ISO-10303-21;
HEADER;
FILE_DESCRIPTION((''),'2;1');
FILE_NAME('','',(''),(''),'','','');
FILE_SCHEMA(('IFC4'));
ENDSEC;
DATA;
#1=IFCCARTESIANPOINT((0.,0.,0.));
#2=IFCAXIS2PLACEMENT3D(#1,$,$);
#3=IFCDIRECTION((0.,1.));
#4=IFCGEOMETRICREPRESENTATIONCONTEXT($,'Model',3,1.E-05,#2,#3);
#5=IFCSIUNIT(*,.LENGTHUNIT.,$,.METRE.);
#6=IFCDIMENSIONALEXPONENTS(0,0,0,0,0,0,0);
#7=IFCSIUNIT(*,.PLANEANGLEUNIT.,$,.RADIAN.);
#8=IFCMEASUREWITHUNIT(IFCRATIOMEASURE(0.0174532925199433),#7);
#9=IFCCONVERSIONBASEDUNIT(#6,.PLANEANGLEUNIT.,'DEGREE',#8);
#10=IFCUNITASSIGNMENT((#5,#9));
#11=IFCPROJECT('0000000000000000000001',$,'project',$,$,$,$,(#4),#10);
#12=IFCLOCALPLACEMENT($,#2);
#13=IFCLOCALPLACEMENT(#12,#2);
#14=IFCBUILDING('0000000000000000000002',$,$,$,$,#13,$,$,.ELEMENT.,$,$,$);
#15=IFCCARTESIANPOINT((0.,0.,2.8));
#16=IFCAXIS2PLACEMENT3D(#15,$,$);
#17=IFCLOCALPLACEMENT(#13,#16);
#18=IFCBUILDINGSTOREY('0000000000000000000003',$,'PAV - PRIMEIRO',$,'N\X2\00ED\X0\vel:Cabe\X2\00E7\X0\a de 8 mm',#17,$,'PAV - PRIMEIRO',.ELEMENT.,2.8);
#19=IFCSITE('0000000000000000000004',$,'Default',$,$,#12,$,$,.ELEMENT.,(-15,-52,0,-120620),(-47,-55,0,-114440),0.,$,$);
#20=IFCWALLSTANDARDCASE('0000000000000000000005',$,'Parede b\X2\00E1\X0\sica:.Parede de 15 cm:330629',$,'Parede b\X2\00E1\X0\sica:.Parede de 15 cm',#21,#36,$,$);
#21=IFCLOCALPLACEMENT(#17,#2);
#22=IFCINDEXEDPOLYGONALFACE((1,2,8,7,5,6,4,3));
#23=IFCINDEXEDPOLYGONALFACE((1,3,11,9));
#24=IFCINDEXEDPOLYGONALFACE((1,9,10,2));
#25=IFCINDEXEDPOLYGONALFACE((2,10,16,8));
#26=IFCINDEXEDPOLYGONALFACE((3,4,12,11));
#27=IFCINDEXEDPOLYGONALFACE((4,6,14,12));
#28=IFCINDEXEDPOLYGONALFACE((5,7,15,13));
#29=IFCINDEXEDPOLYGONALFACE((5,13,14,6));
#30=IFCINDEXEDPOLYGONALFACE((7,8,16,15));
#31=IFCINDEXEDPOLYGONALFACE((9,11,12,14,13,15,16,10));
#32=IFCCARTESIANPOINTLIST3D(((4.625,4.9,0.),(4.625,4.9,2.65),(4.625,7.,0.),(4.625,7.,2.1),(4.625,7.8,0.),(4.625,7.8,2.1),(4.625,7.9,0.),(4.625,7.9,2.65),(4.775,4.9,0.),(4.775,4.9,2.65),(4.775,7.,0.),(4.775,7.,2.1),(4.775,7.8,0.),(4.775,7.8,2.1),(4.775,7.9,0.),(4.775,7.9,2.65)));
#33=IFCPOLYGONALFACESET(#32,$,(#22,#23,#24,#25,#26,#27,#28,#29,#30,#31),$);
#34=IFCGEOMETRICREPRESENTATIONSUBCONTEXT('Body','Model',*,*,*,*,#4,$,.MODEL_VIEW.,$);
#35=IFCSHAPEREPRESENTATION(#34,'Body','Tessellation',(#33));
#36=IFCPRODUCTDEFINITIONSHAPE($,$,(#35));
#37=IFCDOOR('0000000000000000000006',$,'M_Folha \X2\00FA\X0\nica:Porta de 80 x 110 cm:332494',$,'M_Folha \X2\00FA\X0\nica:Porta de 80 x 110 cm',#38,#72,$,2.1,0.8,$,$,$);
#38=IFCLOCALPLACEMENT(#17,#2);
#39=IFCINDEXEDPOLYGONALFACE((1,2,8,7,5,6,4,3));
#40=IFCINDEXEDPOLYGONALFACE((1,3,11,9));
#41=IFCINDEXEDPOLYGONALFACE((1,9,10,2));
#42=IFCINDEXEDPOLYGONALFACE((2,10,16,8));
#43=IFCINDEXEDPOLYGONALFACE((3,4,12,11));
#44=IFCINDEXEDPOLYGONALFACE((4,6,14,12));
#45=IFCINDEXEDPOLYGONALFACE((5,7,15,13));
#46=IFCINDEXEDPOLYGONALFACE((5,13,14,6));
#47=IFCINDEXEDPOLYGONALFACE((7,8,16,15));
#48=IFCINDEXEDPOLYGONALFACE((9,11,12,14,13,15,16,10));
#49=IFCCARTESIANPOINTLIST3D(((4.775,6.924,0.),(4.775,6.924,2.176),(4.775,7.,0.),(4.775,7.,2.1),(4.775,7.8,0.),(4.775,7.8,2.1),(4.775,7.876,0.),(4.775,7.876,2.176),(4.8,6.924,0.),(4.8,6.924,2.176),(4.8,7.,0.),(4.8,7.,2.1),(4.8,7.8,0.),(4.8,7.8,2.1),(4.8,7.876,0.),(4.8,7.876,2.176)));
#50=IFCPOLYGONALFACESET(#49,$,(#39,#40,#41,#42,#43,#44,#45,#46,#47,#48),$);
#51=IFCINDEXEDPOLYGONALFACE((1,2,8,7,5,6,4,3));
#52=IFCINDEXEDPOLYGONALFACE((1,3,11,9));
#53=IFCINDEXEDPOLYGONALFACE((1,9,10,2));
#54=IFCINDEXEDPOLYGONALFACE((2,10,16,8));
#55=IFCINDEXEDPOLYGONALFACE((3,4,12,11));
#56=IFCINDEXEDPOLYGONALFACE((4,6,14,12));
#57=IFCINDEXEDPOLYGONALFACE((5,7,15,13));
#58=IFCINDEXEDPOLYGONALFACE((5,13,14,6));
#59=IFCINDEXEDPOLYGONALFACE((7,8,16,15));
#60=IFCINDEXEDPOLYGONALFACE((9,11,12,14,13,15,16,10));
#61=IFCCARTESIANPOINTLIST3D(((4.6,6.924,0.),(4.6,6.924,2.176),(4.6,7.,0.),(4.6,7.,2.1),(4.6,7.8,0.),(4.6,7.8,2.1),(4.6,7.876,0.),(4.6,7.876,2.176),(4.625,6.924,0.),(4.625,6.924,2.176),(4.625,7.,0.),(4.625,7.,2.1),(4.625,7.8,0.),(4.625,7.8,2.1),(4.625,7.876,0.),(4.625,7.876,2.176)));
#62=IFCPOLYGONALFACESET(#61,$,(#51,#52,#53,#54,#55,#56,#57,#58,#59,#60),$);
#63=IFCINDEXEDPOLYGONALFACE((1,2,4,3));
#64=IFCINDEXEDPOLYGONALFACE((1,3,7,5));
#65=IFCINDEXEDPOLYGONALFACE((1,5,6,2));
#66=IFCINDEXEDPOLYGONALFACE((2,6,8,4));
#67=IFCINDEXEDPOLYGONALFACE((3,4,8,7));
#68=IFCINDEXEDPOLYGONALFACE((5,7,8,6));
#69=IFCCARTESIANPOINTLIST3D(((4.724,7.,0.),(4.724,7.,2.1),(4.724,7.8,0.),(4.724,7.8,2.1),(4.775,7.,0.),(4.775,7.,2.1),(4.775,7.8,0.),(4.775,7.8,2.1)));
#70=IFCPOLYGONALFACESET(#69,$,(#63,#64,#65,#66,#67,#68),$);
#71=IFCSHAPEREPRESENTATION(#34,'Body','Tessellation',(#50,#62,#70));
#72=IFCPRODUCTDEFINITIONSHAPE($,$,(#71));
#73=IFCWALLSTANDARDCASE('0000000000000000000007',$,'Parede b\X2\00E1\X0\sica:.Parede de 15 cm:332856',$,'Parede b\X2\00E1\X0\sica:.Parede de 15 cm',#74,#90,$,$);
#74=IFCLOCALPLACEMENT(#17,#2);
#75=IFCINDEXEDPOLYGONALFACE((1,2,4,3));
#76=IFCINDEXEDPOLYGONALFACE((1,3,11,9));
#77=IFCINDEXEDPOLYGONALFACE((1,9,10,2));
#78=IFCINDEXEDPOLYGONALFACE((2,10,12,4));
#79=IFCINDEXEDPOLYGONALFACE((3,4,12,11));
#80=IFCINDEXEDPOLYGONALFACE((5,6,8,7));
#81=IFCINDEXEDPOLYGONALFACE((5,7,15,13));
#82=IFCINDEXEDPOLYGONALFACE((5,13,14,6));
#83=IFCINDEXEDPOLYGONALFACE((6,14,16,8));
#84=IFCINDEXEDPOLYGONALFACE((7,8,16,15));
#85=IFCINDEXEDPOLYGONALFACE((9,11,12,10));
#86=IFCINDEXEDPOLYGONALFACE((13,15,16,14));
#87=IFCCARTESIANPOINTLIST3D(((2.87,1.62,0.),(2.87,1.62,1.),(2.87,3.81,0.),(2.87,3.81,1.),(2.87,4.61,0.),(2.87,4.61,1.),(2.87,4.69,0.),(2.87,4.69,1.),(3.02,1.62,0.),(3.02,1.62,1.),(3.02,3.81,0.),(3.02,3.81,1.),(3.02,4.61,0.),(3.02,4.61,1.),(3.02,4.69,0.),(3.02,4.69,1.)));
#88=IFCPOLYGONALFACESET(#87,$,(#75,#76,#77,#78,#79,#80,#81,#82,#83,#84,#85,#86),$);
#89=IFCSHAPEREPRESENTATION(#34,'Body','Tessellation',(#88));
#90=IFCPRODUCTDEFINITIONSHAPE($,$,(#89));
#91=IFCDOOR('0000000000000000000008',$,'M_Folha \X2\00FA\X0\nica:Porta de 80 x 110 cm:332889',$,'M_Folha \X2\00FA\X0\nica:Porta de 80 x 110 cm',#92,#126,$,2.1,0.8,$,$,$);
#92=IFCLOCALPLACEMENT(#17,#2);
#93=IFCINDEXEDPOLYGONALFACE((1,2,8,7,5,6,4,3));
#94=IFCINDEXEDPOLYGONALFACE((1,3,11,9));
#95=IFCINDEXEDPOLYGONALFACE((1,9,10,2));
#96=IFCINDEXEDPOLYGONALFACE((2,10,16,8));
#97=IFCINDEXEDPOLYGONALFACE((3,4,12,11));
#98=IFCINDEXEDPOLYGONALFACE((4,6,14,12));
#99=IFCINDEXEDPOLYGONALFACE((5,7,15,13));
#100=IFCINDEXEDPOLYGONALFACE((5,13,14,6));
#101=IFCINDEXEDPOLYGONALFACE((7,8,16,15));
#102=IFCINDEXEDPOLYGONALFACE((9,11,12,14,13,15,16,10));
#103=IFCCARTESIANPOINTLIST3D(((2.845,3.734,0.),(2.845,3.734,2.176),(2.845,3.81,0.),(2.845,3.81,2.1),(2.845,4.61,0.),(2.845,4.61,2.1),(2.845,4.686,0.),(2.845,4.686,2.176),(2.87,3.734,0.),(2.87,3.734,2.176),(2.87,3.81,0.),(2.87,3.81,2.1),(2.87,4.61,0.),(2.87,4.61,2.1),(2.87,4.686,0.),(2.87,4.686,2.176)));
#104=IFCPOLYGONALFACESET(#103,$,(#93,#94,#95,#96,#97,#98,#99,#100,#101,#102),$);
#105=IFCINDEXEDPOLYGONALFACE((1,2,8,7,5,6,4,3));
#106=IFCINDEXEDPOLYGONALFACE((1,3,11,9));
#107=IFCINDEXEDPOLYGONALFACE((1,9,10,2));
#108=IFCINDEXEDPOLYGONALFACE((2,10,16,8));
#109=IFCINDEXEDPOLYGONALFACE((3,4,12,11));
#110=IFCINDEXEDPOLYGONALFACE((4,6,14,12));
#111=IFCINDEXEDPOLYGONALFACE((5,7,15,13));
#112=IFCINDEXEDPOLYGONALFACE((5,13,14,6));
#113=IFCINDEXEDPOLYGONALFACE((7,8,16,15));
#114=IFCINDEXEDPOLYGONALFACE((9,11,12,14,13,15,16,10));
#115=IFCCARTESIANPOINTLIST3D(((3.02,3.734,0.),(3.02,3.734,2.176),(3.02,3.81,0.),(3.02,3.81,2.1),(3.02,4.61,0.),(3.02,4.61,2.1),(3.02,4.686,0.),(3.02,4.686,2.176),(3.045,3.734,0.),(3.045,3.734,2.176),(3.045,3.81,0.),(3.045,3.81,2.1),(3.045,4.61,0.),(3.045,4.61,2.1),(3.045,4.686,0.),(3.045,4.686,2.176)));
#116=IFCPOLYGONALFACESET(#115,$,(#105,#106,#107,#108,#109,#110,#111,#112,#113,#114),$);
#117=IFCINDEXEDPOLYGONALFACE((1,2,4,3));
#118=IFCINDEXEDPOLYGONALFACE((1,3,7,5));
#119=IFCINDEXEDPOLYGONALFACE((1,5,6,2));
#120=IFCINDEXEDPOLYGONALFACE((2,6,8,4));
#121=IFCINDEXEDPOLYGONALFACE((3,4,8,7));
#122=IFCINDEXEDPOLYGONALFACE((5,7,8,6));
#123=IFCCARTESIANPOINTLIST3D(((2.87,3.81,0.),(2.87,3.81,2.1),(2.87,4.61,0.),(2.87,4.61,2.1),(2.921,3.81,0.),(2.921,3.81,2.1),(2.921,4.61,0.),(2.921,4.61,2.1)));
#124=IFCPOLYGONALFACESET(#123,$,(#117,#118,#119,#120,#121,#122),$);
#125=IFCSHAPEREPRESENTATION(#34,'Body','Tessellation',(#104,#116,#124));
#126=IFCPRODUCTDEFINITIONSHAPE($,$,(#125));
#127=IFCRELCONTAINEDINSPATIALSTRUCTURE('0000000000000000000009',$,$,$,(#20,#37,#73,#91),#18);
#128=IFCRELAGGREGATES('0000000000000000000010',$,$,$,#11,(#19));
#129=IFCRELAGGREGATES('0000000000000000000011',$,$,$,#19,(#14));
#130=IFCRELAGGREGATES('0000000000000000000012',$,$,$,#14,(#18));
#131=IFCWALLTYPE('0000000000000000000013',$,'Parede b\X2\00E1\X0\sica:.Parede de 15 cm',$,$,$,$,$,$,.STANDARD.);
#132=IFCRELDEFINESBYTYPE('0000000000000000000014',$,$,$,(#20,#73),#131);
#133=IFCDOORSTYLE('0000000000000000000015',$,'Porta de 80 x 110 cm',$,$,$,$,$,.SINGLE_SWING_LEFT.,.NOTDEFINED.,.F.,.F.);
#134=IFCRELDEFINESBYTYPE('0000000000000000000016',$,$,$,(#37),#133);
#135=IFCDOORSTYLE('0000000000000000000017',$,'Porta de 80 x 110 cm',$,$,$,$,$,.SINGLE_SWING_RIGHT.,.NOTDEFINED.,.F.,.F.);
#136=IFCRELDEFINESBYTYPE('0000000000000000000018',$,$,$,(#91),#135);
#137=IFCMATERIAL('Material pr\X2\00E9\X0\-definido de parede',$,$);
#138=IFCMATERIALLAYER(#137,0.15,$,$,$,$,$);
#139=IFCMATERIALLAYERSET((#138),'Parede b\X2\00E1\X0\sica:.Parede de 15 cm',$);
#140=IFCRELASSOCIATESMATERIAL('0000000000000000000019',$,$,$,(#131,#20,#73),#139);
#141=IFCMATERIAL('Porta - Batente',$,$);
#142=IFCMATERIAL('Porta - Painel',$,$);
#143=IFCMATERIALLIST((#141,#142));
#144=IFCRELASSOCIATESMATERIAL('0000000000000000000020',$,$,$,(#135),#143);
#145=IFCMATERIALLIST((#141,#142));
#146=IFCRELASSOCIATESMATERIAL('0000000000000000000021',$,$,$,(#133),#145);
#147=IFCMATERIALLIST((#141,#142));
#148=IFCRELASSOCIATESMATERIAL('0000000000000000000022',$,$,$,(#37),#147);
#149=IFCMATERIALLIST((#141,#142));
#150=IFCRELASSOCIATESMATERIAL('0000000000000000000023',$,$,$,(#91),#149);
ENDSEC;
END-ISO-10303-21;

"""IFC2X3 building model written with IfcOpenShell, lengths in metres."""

from ifc_helpers import new_model, entity, si_unit, converted_unit, direction, frame, frame_2d, origin, place, context, subcontext, project, spatial, polyline, rectangle, outline, extrude, clip, bounded_halfspace, source, transform, mapped, material, material_list, layer, layer_set, layer_usage, type_object, type_shapes, element, fill, save


model = new_model("IFC2X3")

# Units and contexts
model_context = context("Model", 3, precision=1e-05, world=origin(), true_north=direction((0.0, 1.0)))
body_context = subcontext(model_context, "Body", "Model", "MODEL_VIEW")
ifc_project = project(units=[si_unit("LENGTHUNIT", "METRE"), converted_unit("PLANEANGLEUNIT", "DEGREE", entity("IfcRatioMeasure", 0.0174532925199433), si_unit("PLANEANGLEUNIT", "RADIAN"), dimensions=[0, 0, 0, 0, 0, 0, 0])], contexts=[model_context])

# Site, building, storey
site_placement = place(None, origin())
site = spatial("IfcSite", under=ifc_project, at=site_placement, Name="Default", CompositionType="ELEMENT", RefLatitude=(-15, -52, 0, -120620), RefLongitude=(-47, -55, 0, -114440), RefElevation=0.0)
building_placement = place(site_placement, origin())
building = spatial("IfcBuilding", under=site, at=building_placement, CompositionType="ELEMENT")
storey_placement = place(building_placement, frame((0.0, 0.0, 2.8)))
storey = spatial("IfcBuildingStorey", under=building, at=storey_placement, Name="PAV - PRIMEIRO", ObjectType="Nível:Cabeça de 8 mm", LongName="PAV - PRIMEIRO", CompositionType="ELEMENT", Elevation=2.8)

# Shared definitions
ifc_material_1 = material(Name="Material pré-definido de parede")

# Shared definitions
ifc_material_2 = material(Name="Porta - Batente")
ifc_material_3 = material(Name="Porta - Painel")

# Walls, openings, doors
ifc_layer_1 = layer(ifc_material_1, 0.15)
ifc_layer_set_1 = layer_set([ifc_layer_1], Name="Parede básica:.Parede de 15 cm")
wall_type_1 = type_object("IfcWallType", Name="Parede básica:.Parede de 15 cm", PredefinedType="STANDARD", material=ifc_layer_set_1)
ifc_material_list_1 = material_list([ifc_material_2, ifc_material_3])
door_style_1 = type_object("IfcDoorStyle", Name="Porta de 80 x 110 cm", ConstructionType="NOTDEFINED", OperationType="SINGLE_SWING_RIGHT", ParameterTakesPrecedence=False, Sizeable=False, material=ifc_material_list_1)
shared_shape_1 = source(origin(), body_context, "Body", "SweptSolid", [
    extrude(outline(polyline([(-0.476, -1.107), (0.476, -1.107), (0.476, 1.069), (0.4, 1.069), (0.4, -1.031), (-0.4, -1.031), (-0.4, 1.069), (-0.476, 1.069), (-0.476, -1.107)])), frame((0.4, 0.15, 1.069), z_axis=(0.0, 1.0, 0.0), x_axis=(1.0, 0.0, 0.0)), (0.0, 0.0, 1.0), 0.025),
    extrude(outline(polyline([(-1.107, -0.476), (1.069, -0.476), (1.069, -0.4), (-1.031, -0.4), (-1.031, 0.4), (1.069, 0.4), (1.069, 0.476), (-1.107, 0.476), (-1.107, -0.476)])), frame((0.4, -0.025, 1.069), z_axis=(0.0, 1.0, 0.0), x_axis=(0.0, 0.0, -1.0)), (0.0, 0.0, 1.0), 0.025),
    extrude(rectangle(XDim=0.051, YDim=0.8, at=frame_2d((0.0, 0.0), x_axis=(1.0, 0.0))), frame((0.4, 0.1245, 0.0), z_axis=(0.0, 0.0, 1.0), x_axis=(0.0, 1.0, 0.0)), (0.0, 0.0, 1.0), 2.1),
])
type_shapes(door_style_1, [shared_shape_1])
ifc_layer_usage_1 = layer_usage(ifc_layer_set_1, "AXIS2", "NEGATIVE", 0.075)
wall_1_placement = place(storey_placement, frame((4.7, 4.9, 0.0), z_axis=(0.0, 0.0, 1.0), x_axis=(0.0, 1.0, 0.0)))
wall_1 = element("IfcWallStandardCase", 1, at=wall_1_placement, inside=storey, type_object=wall_type_1, material=ifc_layer_usage_1, Name="Parede básica:.Parede de 15 cm:330629", ObjectType="Parede básica:.Parede de 15 cm", context=body_context, shape_type="Clipping", body=[
    clip(extrude(rectangle(XDim=3.0, YDim=0.15, at=frame_2d((1.5, 0.0), x_axis=(-1.0, 0.0))), origin(), (0.0, 0.0, 1.0), 2.65), bounded_halfspace(frame((0.0, -0.075, 2.65), z_axis=(0.0, 0.0, -1.0), x_axis=(-1.0, 0.0, 0.0)), True, frame((0.0, -0.075, 2.65)), polyline([(0.0, 0.0), (3.0, 0.0), (3.0, 0.15), (0.0, 0.15), (0.0, 0.0)]))),
])
opening_1_placement = place(wall_1_placement, frame((2.9, 0.075, 0.0)))
opening_1 = element("IfcOpeningElement", 2, at=opening_1_placement, cuts=wall_1, ObjectType="Opening", context=body_context, shape_type="SweptSolid", body=[
    extrude(rectangle(XDim=0.8, YDim=2.1, at=frame_2d((1.05, 0.4), x_axis=(0.0, -1.0))), frame((0.0, 0.0, 0.0), z_axis=(0.0, -1.0, 0.0), x_axis=(0.0, 0.0, 1.0)), (0.0, 0.0, 1.0), 0.15),
])
ifc_material_list_2 = material_list([ifc_material_2, ifc_material_3])
ifc_material_list_3 = material_list([ifc_material_2, ifc_material_3])
door_style_2 = type_object("IfcDoorStyle", Name="Porta de 80 x 110 cm", ConstructionType="NOTDEFINED", OperationType="SINGLE_SWING_LEFT", ParameterTakesPrecedence=False, Sizeable=False, material=ifc_material_list_3)
shared_shape_2 = source(origin(), body_context, "Body", "SweptSolid", [
    extrude(outline(polyline([(-0.476, -1.107), (0.476, -1.107), (0.476, 1.069), (0.4, 1.069), (0.4, -1.031), (-0.4, -1.031), (-0.4, 1.069), (-0.476, 1.069), (-0.476, -1.107)])), frame((0.4, 0.175, 1.069), z_axis=(0.0, -1.0, 0.0), x_axis=(-1.0, 0.0, 0.0)), (0.0, 0.0, 1.0), 0.025),
    extrude(outline(polyline([(-1.107, -0.476), (1.069, -0.476), (1.069, -0.4), (-1.031, -0.4), (-1.031, 0.4), (1.069, 0.4), (1.069, 0.476), (-1.107, 0.476), (-1.107, -0.476)])), frame((0.4, 0.0, 1.069), z_axis=(0.0, -1.0, 0.0), x_axis=(0.0, 0.0, -1.0)), (0.0, 0.0, 1.0), 0.025),
    extrude(rectangle(XDim=0.8, YDim=0.051, at=frame_2d((0.0, 0.0), x_axis=(1.0, 0.0))), frame((0.4, 0.1245, 0.0)), (0.0, 0.0, 1.0), 2.1),
])
type_shapes(door_style_2, [shared_shape_2])
door_1_placement = place(opening_1_placement, frame((0.0, 0.0, 0.0), z_axis=(0.0, 0.0, 1.0), x_axis=(-1.0, 0.0, 0.0)))
door_1 = element("IfcDoor", 3, at=door_1_placement, inside=storey, type_object=door_style_2, material=ifc_material_list_2, Name="M_Folha única:Porta de 80 x 110 cm:332494", ObjectType="M_Folha única:Porta de 80 x 110 cm", OverallHeight=2.1, OverallWidth=0.8, context=body_context, shape_type="MappedRepresentation", body=[
    mapped(shared_shape_2, transform((0.0, 0.0, 0.0), scale=1.0)),
])
fill(opening_1, door_1)
ifc_layer_usage_2 = layer_usage(ifc_layer_set_1, "AXIS2", "NEGATIVE", 0.075)
wall_2_placement = place(storey_placement, frame((2.945, 1.62, 0.0), z_axis=(0.0, 0.0, 1.0), x_axis=(0.0, 1.0, 0.0)))
wall_2 = element("IfcWallStandardCase", 4, at=wall_2_placement, inside=storey, type_object=wall_type_1, material=ifc_layer_usage_2, Name="Parede básica:.Parede de 15 cm:332856", ObjectType="Parede básica:.Parede de 15 cm", context=body_context, shape_type="SweptSolid", body=[
    extrude(rectangle(XDim=3.07, YDim=0.15, at=frame_2d((1.535, 0.0), x_axis=(-1.0, 0.0))), origin(), (0.0, 0.0, 1.0), 1.0),
])
opening_2_placement = place(wall_2_placement, frame((2.19, -0.075, 0.0)))
opening_2 = element("IfcOpeningElement", 5, at=opening_2_placement, cuts=wall_2, ObjectType="Opening", context=body_context, shape_type="SweptSolid", body=[
    extrude(rectangle(XDim=0.8, YDim=2.1, at=frame_2d((1.05, 0.4), x_axis=(0.0, 1.0))), frame((0.0, 0.0, 0.0), z_axis=(0.0, 1.0, 0.0), x_axis=(0.0, 0.0, 1.0)), (0.0, 0.0, 1.0), 0.15),
])
ifc_material_list_4 = material_list([ifc_material_2, ifc_material_3])
door_2_placement = place(opening_2_placement, origin())
door_2 = element("IfcDoor", 6, at=door_2_placement, inside=storey, type_object=door_style_1, material=ifc_material_list_4, Name="M_Folha única:Porta de 80 x 110 cm:332889", ObjectType="M_Folha única:Porta de 80 x 110 cm", OverallHeight=2.1, OverallWidth=0.8, context=body_context, shape_type="MappedRepresentation", body=[
    mapped(shared_shape_1, transform((0.0, 0.0, 0.0), scale=1.0)),
])
fill(opening_2, door_2)

save(model, "model.ifc")
